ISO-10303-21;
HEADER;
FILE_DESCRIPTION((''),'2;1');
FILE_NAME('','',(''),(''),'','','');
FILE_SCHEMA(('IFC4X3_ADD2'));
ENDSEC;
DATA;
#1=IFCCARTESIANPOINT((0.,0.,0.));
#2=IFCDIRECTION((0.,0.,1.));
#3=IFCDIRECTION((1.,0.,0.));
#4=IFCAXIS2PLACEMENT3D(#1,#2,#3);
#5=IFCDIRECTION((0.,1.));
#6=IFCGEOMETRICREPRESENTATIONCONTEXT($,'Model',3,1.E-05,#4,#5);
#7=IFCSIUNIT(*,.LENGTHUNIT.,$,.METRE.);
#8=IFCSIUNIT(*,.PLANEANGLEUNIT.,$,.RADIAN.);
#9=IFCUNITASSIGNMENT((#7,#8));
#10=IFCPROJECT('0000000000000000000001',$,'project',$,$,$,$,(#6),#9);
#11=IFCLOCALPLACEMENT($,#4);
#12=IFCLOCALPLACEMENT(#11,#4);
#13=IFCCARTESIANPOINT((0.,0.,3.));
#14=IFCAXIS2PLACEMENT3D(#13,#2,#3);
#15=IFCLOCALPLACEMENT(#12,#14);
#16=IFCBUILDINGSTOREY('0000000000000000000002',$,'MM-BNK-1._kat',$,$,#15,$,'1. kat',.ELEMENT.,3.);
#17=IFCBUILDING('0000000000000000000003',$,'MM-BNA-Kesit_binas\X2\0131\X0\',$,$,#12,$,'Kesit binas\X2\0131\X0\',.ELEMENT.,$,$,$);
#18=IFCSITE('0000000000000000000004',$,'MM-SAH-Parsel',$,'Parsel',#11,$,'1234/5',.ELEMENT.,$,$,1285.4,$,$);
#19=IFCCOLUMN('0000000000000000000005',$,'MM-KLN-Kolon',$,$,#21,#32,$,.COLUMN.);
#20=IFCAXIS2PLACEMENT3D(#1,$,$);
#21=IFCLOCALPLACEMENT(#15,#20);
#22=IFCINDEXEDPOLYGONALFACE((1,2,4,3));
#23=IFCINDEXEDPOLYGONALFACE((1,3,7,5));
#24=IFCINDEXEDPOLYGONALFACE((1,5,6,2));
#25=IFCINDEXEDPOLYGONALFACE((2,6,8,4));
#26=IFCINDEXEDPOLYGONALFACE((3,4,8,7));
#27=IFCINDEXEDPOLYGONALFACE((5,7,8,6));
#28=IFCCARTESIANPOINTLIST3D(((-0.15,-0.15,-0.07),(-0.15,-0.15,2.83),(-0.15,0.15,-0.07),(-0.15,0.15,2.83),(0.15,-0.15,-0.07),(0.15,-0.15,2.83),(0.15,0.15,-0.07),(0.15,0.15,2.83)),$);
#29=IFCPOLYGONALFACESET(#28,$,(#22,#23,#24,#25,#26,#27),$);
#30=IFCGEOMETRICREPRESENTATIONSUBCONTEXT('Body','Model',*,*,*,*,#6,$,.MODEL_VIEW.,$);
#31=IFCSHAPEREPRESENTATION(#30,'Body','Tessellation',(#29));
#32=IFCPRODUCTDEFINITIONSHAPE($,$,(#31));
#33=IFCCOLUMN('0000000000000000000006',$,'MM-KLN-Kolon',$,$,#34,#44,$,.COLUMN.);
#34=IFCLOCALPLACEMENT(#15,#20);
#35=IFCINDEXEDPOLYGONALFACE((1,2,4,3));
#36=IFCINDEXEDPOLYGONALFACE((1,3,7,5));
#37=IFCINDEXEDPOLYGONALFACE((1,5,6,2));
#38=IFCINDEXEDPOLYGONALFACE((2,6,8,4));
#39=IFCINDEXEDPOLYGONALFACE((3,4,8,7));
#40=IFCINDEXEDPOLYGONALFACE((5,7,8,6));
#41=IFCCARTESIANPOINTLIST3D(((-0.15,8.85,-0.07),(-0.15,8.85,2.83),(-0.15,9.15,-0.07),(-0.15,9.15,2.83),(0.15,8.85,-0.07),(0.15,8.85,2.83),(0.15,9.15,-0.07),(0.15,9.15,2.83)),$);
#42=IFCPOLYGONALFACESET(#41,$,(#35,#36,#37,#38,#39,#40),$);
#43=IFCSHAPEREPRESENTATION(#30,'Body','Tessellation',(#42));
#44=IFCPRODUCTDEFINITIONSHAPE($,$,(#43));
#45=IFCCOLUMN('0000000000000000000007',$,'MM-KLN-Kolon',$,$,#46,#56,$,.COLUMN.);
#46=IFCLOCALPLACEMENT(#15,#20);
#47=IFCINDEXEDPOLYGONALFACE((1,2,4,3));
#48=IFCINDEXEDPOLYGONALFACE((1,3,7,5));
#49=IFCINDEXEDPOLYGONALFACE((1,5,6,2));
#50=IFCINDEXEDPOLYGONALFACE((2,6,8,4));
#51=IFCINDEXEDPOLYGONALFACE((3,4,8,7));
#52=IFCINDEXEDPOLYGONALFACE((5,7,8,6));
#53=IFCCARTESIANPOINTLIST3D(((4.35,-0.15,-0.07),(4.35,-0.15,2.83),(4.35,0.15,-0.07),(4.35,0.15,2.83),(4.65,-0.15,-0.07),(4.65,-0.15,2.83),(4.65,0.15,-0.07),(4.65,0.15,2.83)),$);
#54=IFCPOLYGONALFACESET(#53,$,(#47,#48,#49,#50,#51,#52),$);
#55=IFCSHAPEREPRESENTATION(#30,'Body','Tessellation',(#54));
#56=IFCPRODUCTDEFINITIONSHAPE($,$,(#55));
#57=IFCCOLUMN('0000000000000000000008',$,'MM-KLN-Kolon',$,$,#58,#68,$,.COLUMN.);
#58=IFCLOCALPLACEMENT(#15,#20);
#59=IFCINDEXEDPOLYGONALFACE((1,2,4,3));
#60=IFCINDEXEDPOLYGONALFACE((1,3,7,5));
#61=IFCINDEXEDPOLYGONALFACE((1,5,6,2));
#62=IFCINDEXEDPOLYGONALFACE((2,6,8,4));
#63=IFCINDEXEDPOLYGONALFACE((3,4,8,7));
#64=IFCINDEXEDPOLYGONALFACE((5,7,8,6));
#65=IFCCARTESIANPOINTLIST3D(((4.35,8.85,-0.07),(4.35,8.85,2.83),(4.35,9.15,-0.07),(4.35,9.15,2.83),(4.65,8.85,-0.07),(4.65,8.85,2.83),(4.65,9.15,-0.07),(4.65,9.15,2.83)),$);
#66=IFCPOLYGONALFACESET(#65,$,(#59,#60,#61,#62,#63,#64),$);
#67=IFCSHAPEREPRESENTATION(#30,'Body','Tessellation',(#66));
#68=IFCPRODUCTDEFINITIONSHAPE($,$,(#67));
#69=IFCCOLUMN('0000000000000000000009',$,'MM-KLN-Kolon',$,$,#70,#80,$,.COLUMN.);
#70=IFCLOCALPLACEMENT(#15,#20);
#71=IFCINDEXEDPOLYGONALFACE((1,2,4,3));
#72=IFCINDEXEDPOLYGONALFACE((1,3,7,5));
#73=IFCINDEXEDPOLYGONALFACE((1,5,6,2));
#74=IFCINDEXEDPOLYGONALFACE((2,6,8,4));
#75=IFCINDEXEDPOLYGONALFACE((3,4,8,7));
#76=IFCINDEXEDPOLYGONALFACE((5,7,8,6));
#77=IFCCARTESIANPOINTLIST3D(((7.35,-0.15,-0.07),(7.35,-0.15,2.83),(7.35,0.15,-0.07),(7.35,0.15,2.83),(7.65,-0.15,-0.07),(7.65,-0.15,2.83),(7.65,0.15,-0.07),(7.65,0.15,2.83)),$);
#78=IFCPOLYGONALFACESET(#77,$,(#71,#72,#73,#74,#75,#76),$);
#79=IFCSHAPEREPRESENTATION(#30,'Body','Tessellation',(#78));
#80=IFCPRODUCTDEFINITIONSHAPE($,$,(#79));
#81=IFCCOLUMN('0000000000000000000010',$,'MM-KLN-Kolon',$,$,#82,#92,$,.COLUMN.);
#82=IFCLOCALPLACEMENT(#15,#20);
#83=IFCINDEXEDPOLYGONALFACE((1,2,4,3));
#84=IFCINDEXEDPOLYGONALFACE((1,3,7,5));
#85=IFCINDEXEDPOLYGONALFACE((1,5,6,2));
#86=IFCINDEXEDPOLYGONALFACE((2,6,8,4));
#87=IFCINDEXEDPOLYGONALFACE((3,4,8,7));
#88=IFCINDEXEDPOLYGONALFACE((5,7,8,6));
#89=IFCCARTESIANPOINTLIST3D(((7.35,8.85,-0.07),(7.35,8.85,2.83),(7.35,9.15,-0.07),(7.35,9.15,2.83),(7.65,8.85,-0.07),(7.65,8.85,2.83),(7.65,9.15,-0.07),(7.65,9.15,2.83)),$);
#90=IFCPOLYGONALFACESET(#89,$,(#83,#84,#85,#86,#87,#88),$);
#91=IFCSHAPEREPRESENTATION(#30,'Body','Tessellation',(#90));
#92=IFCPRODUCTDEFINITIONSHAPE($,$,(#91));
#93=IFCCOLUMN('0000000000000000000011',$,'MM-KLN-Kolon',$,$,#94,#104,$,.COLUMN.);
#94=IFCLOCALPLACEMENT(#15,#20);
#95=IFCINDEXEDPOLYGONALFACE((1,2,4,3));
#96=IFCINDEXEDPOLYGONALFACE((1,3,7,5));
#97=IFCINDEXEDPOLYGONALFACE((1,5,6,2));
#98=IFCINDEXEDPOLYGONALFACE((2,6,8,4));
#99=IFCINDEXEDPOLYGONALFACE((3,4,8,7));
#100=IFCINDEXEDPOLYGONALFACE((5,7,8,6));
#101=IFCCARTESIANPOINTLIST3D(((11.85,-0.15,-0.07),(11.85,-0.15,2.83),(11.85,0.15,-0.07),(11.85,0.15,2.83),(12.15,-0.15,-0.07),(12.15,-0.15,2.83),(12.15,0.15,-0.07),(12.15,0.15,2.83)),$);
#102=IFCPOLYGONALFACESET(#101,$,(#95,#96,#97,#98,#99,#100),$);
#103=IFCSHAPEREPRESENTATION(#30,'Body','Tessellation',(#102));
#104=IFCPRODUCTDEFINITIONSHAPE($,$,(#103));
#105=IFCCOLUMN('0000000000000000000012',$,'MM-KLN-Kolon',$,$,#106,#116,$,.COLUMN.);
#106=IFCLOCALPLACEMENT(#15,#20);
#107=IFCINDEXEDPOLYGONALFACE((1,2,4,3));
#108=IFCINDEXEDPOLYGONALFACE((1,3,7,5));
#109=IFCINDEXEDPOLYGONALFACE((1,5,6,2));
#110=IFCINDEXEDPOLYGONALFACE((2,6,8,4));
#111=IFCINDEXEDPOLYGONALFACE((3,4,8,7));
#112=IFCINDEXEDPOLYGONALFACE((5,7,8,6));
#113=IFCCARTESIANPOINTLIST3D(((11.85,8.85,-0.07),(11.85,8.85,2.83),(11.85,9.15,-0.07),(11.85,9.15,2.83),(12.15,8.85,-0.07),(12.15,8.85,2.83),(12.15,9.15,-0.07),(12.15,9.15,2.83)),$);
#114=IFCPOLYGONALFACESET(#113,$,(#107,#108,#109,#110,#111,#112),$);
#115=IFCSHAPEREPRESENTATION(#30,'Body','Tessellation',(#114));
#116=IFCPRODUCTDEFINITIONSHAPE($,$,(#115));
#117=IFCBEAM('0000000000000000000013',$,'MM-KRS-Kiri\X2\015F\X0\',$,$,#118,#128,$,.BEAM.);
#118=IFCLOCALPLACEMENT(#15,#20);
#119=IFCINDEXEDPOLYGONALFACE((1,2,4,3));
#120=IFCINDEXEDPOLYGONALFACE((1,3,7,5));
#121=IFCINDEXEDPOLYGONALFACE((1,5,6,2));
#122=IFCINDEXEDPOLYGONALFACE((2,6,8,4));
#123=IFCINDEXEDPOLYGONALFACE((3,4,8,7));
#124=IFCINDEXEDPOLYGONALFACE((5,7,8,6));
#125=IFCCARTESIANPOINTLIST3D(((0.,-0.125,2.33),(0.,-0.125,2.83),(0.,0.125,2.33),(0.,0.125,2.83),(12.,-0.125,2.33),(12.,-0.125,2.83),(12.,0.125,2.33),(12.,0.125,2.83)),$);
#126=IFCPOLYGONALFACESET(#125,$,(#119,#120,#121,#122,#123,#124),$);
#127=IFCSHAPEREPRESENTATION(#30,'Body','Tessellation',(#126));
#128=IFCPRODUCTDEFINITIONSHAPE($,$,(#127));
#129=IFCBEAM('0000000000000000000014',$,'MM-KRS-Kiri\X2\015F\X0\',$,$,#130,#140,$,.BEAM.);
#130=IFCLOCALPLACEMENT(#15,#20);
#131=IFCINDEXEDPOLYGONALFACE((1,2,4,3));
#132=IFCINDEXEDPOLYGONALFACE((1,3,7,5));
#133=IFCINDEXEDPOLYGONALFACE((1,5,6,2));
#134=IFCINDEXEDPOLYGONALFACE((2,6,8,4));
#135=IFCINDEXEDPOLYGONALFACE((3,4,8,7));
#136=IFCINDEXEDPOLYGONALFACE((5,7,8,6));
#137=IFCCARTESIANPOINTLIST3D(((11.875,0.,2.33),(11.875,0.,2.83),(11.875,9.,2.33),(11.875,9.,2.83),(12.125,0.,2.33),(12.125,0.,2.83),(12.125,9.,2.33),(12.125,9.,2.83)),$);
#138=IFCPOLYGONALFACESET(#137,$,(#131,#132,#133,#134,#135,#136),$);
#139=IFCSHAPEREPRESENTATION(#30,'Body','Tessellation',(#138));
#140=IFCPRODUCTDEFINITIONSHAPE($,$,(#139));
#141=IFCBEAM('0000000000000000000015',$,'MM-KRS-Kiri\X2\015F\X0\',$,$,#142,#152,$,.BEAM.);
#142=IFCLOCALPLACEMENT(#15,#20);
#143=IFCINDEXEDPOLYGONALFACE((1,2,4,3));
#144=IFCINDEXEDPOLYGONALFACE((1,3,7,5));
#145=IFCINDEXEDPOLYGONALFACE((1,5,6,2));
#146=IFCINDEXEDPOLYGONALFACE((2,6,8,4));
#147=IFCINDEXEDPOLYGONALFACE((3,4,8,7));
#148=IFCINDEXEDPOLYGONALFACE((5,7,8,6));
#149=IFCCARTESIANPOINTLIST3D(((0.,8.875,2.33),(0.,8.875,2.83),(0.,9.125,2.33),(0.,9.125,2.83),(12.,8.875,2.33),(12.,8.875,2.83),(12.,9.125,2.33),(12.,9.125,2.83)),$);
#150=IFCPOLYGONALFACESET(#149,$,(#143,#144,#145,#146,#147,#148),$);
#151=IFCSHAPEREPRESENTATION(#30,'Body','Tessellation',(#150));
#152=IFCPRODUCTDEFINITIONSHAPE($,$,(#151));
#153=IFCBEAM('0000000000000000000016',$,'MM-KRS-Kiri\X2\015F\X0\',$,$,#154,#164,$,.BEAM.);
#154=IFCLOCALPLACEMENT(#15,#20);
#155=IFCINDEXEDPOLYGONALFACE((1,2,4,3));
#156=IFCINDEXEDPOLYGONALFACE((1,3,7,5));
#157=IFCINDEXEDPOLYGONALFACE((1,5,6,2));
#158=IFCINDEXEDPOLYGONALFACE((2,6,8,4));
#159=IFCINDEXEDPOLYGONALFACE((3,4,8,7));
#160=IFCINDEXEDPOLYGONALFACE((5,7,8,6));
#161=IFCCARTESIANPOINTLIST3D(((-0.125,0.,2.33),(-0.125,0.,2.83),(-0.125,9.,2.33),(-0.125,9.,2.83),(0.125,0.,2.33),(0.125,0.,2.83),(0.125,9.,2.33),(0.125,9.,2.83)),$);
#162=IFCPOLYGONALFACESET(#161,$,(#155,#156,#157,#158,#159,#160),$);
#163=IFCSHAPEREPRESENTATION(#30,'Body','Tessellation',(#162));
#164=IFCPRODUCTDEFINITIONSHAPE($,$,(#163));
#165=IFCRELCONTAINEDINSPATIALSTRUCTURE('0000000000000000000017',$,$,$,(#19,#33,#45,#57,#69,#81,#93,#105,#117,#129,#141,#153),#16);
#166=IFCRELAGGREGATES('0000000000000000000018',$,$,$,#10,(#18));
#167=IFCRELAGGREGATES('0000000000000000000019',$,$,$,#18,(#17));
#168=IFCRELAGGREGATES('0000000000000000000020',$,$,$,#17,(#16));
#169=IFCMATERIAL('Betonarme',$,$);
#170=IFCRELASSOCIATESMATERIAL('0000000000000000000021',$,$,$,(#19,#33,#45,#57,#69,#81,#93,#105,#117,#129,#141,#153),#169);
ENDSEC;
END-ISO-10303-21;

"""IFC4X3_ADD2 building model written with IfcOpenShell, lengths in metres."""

from ifc_helpers import new_model, si_unit, direction, frame, origin_with_axes, place, context, subcontext, project, spatial, polyline, outline, extrude, material, element, save


model = new_model("IFC4X3_ADD2")

# Units and contexts
model_context = context("Model", 3, precision=1e-05, world=origin_with_axes(), true_north=direction((0.0, 1.0)))
body_context = subcontext(model_context, "Body", "Model", "MODEL_VIEW")
ifc_project = project(units=[si_unit("LENGTHUNIT", "METRE"), si_unit("PLANEANGLEUNIT", "RADIAN")], contexts=[model_context])

# Site, building, storey
site_placement = place(None, origin_with_axes())
site = spatial("IfcSite", under=ifc_project, at=site_placement, Name="MM-SAH-Parsel", ObjectType="Parsel", LongName="1234/5", CompositionType="ELEMENT", RefElevation=1285.4)
building_placement = place(site_placement, origin_with_axes())
building = spatial("IfcBuilding", under=site, at=building_placement, Name="MM-BNA-Kesit_binası", LongName="Kesit binası", CompositionType="ELEMENT")
storey_placement = place(building_placement, frame((0.0, 0.0, 3.0), z_axis=(0.0, 0.0, 1.0), x_axis=(1.0, 0.0, 0.0)))
storey = spatial("IfcBuildingStorey", under=building, at=storey_placement, Name="MM-BNK-1._kat", LongName="1. kat", CompositionType="ELEMENT", Elevation=3.0)

# Columns
ifc_material_1 = material(Name="Betonarme")
column_1_placement = place(storey_placement, origin_with_axes())
element("IfcColumn", 1, at=column_1_placement, inside=storey, material=ifc_material_1, Name="MM-KLN-Kolon", PredefinedType="COLUMN", context=body_context, shape_type="SweptSolid", body=[
    extrude(outline(polyline([(-0.15, -0.15), (0.15, -0.15), (0.15, 0.15), (-0.15, 0.15), (-0.15, -0.15)])), frame((0.0, 0.0, -0.07)), (0.0, 0.0, 1.0), 2.9),
])
column_2_placement = place(storey_placement, origin_with_axes())
element("IfcColumn", 2, at=column_2_placement, inside=storey, material=ifc_material_1, Name="MM-KLN-Kolon", PredefinedType="COLUMN", context=body_context, shape_type="SweptSolid", body=[
    extrude(outline(polyline([(-0.15, 8.85), (0.15, 8.85), (0.15, 9.15), (-0.15, 9.15), (-0.15, 8.85)])), frame((0.0, 0.0, -0.07)), (0.0, 0.0, 1.0), 2.9),
])
column_3_placement = place(storey_placement, origin_with_axes())
element("IfcColumn", 3, at=column_3_placement, inside=storey, material=ifc_material_1, Name="MM-KLN-Kolon", PredefinedType="COLUMN", context=body_context, shape_type="SweptSolid", body=[
    extrude(outline(polyline([(4.35, -0.15), (4.65, -0.15), (4.65, 0.15), (4.35, 0.15), (4.35, -0.15)])), frame((0.0, 0.0, -0.07)), (0.0, 0.0, 1.0), 2.9),
])
column_4_placement = place(storey_placement, origin_with_axes())
element("IfcColumn", 4, at=column_4_placement, inside=storey, material=ifc_material_1, Name="MM-KLN-Kolon", PredefinedType="COLUMN", context=body_context, shape_type="SweptSolid", body=[
    extrude(outline(polyline([(4.35, 8.85), (4.65, 8.85), (4.65, 9.15), (4.35, 9.15), (4.35, 8.85)])), frame((0.0, 0.0, -0.07)), (0.0, 0.0, 1.0), 2.9),
])
column_5_placement = place(storey_placement, origin_with_axes())
element("IfcColumn", 5, at=column_5_placement, inside=storey, material=ifc_material_1, Name="MM-KLN-Kolon", PredefinedType="COLUMN", context=body_context, shape_type="SweptSolid", body=[
    extrude(outline(polyline([(7.35, -0.15), (7.65, -0.15), (7.65, 0.15), (7.35, 0.15), (7.35, -0.15)])), frame((0.0, 0.0, -0.07)), (0.0, 0.0, 1.0), 2.9),
])
column_6_placement = place(storey_placement, origin_with_axes())
element("IfcColumn", 6, at=column_6_placement, inside=storey, material=ifc_material_1, Name="MM-KLN-Kolon", PredefinedType="COLUMN", context=body_context, shape_type="SweptSolid", body=[
    extrude(outline(polyline([(7.35, 8.85), (7.65, 8.85), (7.65, 9.15), (7.35, 9.15), (7.35, 8.85)])), frame((0.0, 0.0, -0.07)), (0.0, 0.0, 1.0), 2.9),
])
column_7_placement = place(storey_placement, origin_with_axes())
element("IfcColumn", 7, at=column_7_placement, inside=storey, material=ifc_material_1, Name="MM-KLN-Kolon", PredefinedType="COLUMN", context=body_context, shape_type="SweptSolid", body=[
    extrude(outline(polyline([(11.85, -0.15), (12.15, -0.15), (12.15, 0.15), (11.85, 0.15), (11.85, -0.15)])), frame((0.0, 0.0, -0.07)), (0.0, 0.0, 1.0), 2.9),
])
column_8_placement = place(storey_placement, origin_with_axes())
element("IfcColumn", 8, at=column_8_placement, inside=storey, material=ifc_material_1, Name="MM-KLN-Kolon", PredefinedType="COLUMN", context=body_context, shape_type="SweptSolid", body=[
    extrude(outline(polyline([(11.85, 8.85), (12.15, 8.85), (12.15, 9.15), (11.85, 9.15), (11.85, 8.85)])), frame((0.0, 0.0, -0.07)), (0.0, 0.0, 1.0), 2.9),
])

# Beams
beam_1_placement = place(storey_placement, origin_with_axes())
element("IfcBeam", 9, at=beam_1_placement, inside=storey, material=ifc_material_1, Name="MM-KRS-Kiriş", PredefinedType="BEAM", context=body_context, shape_type="SweptSolid", body=[
    extrude(outline(polyline([(0.0, 0.125), (12.0, 0.125), (12.0, -0.125), (0.0, -0.125), (0.0, 0.125)])), frame((0.0, 0.0, 2.33)), (0.0, 0.0, 1.0), 0.5),
])
beam_2_placement = place(storey_placement, origin_with_axes())
element("IfcBeam", 10, at=beam_2_placement, inside=storey, material=ifc_material_1, Name="MM-KRS-Kiriş", PredefinedType="BEAM", context=body_context, shape_type="SweptSolid", body=[
    extrude(outline(polyline([(11.875, 0.0), (11.875, 9.0), (12.125, 9.0), (12.125, 0.0), (11.875, 0.0)])), frame((0.0, 0.0, 2.33)), (0.0, 0.0, 1.0), 0.5),
])
beam_3_placement = place(storey_placement, origin_with_axes())
element("IfcBeam", 11, at=beam_3_placement, inside=storey, material=ifc_material_1, Name="MM-KRS-Kiriş", PredefinedType="BEAM", context=body_context, shape_type="SweptSolid", body=[
    extrude(outline(polyline([(12.0, 8.875), (0.0, 8.875), (0.0, 9.125), (12.0, 9.125), (12.0, 8.875)])), frame((0.0, 0.0, 2.33)), (0.0, 0.0, 1.0), 0.5),
])
beam_4_placement = place(storey_placement, origin_with_axes())
element("IfcBeam", 12, at=beam_4_placement, inside=storey, material=ifc_material_1, Name="MM-KRS-Kiriş", PredefinedType="BEAM", context=body_context, shape_type="SweptSolid", body=[
    extrude(outline(polyline([(0.125, 9.0), (0.125, 0.0), (-0.125, 0.0), (-0.125, 9.0), (0.125, 9.0)])), frame((0.0, 0.0, 2.33)), (0.0, 0.0, 1.0), 0.5),
])

save(model, "model.ifc")
